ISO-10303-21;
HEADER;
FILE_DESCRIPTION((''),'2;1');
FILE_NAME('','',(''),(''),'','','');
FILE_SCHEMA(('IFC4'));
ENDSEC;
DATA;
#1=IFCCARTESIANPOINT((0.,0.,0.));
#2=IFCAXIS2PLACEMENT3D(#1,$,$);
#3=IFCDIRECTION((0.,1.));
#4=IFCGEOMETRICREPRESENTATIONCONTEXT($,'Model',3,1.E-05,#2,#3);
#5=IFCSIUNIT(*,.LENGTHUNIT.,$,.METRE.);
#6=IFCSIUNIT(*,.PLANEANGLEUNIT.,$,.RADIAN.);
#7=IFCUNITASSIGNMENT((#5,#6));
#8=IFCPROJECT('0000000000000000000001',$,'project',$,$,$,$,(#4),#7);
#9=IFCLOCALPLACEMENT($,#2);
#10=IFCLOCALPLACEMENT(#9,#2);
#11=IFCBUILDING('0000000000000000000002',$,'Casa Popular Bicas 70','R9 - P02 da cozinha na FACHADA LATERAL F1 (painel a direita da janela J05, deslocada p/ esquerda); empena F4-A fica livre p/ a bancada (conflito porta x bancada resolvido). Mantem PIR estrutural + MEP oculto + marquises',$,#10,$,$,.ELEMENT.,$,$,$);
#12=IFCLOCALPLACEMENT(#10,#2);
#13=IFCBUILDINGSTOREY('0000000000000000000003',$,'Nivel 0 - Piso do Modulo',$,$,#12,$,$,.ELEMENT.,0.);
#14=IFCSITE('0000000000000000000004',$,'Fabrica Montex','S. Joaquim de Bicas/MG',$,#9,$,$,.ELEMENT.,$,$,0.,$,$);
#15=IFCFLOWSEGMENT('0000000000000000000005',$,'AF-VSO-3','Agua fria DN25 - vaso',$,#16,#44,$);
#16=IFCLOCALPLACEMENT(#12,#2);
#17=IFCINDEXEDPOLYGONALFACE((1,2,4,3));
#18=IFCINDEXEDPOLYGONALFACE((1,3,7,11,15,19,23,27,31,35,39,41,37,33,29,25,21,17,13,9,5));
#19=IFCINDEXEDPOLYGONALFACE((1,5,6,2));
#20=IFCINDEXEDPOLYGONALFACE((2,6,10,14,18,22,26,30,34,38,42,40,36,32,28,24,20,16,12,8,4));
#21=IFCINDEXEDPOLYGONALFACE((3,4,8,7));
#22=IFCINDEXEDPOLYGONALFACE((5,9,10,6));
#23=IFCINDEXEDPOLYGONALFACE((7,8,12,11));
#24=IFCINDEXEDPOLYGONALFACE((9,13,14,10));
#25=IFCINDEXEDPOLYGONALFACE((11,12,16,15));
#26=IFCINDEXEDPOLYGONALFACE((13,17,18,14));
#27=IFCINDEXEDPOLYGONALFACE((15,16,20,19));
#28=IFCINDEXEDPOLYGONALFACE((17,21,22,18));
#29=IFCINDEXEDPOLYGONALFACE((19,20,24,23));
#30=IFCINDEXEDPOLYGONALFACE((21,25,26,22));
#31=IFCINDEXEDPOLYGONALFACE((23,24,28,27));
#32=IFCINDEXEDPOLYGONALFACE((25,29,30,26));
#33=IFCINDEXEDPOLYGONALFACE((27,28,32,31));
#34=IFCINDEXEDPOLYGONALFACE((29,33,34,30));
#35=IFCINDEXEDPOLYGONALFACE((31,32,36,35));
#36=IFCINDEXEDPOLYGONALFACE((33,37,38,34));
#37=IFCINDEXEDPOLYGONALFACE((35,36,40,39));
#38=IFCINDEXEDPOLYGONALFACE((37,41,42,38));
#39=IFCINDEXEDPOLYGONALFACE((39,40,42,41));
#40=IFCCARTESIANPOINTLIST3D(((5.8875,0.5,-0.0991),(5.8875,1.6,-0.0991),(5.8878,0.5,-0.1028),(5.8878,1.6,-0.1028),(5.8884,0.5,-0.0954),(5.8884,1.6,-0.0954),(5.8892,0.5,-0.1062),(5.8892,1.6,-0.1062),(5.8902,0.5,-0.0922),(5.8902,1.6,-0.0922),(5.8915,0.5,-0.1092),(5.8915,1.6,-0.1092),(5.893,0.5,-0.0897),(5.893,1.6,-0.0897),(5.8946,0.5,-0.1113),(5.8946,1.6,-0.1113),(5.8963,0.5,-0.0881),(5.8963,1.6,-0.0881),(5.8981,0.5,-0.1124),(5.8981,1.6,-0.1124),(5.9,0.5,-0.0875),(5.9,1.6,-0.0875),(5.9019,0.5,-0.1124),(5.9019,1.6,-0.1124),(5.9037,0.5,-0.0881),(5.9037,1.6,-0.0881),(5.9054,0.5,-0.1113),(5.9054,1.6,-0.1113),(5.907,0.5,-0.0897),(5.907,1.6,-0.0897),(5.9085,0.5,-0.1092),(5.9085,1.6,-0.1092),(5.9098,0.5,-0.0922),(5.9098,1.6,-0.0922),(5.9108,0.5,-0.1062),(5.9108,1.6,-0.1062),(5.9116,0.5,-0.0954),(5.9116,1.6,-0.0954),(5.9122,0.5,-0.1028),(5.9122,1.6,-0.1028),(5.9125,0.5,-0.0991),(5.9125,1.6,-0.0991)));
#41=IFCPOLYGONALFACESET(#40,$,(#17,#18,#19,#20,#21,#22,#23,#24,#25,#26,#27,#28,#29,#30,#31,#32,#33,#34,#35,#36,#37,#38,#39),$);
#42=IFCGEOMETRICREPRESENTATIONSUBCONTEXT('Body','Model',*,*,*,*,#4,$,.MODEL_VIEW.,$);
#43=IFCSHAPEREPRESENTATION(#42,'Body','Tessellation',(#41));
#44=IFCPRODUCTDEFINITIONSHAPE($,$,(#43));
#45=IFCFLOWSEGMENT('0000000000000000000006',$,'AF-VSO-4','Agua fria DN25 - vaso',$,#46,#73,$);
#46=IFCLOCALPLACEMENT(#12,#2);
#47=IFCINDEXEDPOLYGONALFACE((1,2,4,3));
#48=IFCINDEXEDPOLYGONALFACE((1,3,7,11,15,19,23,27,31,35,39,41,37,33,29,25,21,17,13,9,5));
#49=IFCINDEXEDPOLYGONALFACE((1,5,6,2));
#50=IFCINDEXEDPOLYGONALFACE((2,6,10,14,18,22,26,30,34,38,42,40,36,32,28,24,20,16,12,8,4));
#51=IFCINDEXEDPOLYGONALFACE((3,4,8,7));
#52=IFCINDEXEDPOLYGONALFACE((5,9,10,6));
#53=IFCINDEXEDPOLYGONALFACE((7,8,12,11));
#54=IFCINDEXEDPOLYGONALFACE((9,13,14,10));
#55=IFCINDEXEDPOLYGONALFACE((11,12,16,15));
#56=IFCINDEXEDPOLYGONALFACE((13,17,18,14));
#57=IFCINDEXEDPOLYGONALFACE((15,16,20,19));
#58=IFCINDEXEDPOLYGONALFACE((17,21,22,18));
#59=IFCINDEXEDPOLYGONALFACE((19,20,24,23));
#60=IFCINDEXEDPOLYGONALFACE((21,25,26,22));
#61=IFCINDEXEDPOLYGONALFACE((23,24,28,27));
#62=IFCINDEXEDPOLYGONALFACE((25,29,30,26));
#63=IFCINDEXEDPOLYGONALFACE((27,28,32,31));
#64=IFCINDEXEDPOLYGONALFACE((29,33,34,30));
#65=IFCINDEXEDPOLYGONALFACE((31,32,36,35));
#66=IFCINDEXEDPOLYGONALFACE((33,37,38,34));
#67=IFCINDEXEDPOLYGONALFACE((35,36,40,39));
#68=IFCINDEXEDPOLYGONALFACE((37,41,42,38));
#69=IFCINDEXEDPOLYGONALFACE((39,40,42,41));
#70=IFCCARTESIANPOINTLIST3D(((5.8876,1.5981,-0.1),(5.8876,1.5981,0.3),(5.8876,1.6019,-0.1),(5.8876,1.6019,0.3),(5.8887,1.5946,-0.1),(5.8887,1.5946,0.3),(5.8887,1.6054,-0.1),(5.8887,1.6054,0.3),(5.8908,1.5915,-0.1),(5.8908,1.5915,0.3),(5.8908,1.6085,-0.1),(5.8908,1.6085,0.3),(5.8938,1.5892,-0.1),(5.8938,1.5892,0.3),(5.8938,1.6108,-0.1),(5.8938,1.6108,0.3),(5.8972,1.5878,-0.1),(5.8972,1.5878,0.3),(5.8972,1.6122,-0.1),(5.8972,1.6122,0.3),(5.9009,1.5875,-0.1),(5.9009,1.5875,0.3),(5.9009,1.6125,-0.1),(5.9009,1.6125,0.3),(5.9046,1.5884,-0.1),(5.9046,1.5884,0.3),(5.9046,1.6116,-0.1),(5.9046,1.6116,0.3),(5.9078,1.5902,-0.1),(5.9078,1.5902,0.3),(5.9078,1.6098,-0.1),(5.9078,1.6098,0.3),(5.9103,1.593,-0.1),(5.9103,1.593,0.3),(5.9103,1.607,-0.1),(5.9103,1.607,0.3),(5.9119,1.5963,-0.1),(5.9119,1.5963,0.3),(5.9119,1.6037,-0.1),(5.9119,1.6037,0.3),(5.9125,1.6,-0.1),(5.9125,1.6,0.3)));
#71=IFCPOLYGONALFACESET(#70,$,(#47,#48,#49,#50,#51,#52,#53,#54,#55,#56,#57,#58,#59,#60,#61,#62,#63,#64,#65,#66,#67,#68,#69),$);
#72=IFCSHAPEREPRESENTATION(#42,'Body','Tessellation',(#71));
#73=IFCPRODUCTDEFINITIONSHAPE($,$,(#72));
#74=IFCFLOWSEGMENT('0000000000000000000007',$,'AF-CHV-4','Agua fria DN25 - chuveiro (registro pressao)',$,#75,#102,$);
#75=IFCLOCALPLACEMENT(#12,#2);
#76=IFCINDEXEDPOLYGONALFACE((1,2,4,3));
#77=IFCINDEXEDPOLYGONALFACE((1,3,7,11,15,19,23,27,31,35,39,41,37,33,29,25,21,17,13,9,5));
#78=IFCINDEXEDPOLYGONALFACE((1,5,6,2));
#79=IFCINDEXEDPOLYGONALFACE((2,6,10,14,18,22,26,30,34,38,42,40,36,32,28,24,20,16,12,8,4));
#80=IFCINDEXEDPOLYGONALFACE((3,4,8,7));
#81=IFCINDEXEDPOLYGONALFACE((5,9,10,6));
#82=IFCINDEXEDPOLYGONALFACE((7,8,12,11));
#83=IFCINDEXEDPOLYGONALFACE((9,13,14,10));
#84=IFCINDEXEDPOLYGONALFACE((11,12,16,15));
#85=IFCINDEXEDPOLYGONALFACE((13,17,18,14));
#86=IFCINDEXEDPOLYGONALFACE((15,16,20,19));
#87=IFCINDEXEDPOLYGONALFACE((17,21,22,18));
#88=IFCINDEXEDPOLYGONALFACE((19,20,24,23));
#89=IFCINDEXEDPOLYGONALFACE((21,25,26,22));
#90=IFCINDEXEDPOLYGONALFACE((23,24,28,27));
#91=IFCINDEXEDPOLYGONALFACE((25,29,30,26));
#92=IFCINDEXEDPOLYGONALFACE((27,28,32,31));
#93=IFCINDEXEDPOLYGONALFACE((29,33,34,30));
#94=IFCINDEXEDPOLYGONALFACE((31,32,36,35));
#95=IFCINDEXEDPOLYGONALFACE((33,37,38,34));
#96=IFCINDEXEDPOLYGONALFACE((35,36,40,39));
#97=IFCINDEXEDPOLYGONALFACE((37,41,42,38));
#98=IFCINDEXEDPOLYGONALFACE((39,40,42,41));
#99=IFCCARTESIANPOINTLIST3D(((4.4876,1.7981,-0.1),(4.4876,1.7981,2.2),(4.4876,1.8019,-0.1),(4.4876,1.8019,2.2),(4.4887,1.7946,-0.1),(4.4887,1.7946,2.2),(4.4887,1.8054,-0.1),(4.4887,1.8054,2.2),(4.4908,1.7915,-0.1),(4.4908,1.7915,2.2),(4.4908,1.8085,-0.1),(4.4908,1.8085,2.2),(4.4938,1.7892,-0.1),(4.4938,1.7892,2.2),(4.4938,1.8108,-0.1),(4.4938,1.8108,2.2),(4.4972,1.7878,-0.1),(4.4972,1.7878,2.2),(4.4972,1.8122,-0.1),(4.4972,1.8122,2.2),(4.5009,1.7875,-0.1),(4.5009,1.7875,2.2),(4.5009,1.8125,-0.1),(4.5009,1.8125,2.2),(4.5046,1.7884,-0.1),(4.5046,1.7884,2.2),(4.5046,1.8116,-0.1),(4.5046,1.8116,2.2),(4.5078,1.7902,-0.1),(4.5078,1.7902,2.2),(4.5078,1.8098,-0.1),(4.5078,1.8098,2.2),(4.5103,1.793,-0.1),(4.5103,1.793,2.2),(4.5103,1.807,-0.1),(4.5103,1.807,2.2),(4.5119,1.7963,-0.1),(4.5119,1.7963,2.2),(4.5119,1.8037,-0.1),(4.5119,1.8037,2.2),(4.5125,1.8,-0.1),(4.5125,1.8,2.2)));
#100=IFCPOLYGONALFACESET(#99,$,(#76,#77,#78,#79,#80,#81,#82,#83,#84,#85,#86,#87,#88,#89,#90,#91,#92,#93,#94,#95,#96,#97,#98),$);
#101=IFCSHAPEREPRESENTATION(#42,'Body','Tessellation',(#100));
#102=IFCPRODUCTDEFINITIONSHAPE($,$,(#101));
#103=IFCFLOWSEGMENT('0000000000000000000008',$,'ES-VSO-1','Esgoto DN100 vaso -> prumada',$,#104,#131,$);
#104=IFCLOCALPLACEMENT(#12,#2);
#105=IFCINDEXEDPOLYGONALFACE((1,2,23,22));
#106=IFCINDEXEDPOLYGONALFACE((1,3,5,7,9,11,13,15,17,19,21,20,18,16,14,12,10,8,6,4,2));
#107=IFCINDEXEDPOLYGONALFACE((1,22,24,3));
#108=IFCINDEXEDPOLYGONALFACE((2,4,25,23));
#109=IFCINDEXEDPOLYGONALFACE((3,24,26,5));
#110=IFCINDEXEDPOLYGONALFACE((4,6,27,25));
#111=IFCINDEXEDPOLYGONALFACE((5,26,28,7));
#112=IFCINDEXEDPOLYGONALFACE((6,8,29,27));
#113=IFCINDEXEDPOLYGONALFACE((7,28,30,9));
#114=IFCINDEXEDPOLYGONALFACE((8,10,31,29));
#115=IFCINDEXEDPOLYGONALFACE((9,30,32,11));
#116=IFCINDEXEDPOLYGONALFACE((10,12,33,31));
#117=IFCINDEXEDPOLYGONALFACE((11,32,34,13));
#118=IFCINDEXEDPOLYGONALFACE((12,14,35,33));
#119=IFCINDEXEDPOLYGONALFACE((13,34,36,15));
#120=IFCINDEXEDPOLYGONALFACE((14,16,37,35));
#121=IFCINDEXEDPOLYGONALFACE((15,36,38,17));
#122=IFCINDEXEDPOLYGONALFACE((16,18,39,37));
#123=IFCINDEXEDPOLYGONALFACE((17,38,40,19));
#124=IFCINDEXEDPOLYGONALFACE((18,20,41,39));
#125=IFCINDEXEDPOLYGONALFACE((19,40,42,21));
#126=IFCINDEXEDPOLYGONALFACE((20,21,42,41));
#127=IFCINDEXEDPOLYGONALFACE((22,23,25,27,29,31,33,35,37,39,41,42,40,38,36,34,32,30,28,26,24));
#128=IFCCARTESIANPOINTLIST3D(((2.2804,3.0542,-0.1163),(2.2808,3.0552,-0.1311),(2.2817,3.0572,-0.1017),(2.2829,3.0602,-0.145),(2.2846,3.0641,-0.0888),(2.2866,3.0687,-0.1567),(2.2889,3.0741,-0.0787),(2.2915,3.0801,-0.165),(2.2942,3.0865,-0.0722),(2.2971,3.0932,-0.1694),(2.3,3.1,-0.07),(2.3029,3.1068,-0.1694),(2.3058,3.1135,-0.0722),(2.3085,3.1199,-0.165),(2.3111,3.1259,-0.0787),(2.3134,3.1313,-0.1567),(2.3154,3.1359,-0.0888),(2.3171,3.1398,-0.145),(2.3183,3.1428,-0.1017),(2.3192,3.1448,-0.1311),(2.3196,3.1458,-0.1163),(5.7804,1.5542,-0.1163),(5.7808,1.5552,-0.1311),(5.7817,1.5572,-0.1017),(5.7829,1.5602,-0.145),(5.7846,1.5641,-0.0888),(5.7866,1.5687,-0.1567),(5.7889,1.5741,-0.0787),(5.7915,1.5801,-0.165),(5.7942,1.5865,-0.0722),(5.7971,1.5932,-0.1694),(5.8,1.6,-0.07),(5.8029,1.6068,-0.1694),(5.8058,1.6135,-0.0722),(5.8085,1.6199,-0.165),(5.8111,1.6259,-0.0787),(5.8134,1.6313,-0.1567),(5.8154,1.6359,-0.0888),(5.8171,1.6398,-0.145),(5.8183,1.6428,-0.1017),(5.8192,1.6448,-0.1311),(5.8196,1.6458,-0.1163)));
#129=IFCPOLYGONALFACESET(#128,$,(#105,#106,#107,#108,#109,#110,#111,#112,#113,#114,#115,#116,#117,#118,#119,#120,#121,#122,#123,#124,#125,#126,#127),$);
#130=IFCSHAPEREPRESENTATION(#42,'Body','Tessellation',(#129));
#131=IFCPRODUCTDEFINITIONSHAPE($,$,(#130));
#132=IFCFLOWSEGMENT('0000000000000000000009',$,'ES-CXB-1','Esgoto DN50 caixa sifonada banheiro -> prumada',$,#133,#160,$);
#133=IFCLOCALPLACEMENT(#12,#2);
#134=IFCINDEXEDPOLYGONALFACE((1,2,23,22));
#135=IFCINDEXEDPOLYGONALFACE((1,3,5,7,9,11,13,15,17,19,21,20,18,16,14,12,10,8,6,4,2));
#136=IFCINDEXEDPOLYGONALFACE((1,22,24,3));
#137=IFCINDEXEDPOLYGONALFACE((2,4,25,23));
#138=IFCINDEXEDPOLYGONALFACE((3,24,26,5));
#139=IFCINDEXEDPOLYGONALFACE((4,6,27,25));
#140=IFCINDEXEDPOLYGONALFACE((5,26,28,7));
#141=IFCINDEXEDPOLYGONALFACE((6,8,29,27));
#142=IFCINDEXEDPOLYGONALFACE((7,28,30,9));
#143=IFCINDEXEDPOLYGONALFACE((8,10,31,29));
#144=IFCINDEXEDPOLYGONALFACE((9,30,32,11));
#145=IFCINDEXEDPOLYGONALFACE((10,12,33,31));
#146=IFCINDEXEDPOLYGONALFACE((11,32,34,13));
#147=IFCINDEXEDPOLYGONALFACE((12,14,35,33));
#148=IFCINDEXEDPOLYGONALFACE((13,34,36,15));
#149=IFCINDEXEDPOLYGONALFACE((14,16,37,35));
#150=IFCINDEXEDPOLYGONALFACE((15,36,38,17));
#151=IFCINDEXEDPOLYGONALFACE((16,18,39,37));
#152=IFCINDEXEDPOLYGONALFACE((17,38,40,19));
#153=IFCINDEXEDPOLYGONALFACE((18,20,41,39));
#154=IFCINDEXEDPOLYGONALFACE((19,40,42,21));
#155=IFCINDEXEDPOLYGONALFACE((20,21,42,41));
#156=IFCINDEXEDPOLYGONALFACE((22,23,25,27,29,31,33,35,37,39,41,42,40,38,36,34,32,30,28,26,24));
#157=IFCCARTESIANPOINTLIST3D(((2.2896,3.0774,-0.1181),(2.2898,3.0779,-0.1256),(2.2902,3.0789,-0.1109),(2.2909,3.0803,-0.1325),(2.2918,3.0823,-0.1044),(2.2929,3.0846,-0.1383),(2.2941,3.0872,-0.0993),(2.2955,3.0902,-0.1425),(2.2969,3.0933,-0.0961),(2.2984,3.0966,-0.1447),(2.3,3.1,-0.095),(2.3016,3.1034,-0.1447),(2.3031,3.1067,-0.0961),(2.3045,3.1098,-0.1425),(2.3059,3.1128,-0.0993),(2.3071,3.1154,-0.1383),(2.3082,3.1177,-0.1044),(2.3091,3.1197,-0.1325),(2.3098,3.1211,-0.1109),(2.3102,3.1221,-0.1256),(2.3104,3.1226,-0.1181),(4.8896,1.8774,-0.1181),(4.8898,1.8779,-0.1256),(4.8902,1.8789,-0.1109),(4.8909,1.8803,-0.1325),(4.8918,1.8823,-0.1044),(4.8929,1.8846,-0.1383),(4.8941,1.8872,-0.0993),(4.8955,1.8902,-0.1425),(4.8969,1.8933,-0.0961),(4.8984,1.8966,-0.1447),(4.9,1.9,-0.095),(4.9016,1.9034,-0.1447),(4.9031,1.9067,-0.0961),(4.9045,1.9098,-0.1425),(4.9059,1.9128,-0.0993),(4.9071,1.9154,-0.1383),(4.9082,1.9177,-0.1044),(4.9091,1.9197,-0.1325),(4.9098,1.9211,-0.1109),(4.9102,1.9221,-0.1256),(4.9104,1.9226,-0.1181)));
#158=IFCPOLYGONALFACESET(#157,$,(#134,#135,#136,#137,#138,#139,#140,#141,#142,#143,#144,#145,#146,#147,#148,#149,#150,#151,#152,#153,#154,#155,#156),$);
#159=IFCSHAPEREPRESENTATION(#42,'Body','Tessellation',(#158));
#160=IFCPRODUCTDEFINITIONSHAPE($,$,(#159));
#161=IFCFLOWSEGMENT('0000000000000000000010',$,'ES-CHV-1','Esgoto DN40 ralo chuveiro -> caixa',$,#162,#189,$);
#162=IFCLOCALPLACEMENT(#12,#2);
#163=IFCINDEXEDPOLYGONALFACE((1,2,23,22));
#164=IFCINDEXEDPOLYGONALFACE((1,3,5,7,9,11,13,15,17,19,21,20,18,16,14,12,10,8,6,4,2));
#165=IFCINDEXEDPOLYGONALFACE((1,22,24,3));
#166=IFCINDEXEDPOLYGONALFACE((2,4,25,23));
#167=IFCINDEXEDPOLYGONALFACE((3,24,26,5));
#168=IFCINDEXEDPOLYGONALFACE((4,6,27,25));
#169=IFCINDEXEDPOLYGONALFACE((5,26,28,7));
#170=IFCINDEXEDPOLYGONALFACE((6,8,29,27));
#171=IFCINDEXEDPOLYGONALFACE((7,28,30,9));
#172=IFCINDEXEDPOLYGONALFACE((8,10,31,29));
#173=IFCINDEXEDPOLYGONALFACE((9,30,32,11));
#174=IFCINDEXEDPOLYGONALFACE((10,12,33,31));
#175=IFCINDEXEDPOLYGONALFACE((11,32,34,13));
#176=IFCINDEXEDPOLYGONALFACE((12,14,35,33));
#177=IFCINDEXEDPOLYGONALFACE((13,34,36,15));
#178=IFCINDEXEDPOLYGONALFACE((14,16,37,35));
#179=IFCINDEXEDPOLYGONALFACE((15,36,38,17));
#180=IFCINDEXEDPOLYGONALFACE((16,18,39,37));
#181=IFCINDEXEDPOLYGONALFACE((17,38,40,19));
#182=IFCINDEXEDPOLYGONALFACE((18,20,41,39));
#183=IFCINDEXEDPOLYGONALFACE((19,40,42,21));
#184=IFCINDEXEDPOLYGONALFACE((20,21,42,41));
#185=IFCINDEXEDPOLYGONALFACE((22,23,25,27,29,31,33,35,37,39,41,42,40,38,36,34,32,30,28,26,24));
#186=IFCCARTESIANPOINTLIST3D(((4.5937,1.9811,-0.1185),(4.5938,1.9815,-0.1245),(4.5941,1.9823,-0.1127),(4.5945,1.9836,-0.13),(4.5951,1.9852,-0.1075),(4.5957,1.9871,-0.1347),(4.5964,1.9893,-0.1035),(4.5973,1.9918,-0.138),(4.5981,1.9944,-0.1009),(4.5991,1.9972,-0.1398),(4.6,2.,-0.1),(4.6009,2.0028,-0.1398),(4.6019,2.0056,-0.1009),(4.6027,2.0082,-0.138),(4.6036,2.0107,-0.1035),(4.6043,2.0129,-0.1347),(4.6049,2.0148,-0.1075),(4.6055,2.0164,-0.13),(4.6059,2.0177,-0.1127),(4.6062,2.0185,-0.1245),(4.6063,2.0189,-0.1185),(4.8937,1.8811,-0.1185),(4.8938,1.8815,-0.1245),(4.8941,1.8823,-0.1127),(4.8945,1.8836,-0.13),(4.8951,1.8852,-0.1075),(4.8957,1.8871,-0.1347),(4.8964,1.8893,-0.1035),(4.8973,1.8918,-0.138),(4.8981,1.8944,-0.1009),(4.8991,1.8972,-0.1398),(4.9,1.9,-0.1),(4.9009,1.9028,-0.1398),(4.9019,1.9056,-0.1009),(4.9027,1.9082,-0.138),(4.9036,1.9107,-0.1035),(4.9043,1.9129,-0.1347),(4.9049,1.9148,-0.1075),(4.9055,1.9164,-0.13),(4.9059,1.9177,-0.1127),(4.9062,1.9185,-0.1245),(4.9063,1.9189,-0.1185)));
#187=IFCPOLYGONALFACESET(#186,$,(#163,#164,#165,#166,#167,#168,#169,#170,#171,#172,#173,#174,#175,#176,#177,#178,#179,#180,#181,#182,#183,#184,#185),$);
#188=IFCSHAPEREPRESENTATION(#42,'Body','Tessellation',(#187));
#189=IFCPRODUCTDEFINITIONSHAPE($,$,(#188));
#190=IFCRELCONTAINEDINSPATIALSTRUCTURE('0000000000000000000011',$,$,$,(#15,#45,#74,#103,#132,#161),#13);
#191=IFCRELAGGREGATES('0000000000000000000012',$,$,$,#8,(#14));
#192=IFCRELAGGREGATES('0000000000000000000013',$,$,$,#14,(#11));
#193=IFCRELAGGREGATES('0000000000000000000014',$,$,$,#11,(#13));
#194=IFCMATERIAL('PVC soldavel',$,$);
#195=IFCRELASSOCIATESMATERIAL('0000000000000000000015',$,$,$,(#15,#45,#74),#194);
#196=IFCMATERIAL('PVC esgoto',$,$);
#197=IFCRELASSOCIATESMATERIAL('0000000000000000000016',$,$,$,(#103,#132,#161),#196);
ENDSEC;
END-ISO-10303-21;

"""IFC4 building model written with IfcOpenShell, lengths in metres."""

from ifc_helpers import new_model, si_unit, direction, frame, origin, origin_2d, place, context, subcontext, project, spatial, circle, extrude, material, element, save


model = new_model("IFC4")

# Units and contexts
model_context = context("Model", 3, precision=1e-05, world=origin(), true_north=direction((0.0, 1.0)))
body_context = subcontext(model_context, "Body", "Model", "MODEL_VIEW")
ifc_project = project(units=[si_unit("LENGTHUNIT", "METRE"), si_unit("PLANEANGLEUNIT", "RADIAN")], contexts=[model_context])

# Site, building, storey
site_placement = place(None, origin())
site = spatial("IfcSite", under=ifc_project, at=site_placement, Name="Fabrica Montex", Description="S. Joaquim de Bicas/MG", CompositionType="ELEMENT", RefElevation=0.0)
building_placement = place(site_placement, origin())
building = spatial("IfcBuilding", under=site, at=building_placement, Name="Casa Popular Bicas 70", Description="R9 - P02 da cozinha na FACHADA LATERAL F1 (painel a direita da janela J05, deslocada p/ esquerda); empena F4-A fica livre p/ a bancada (conflito porta x bancada resolvido). Mantem PIR estrutural + MEP oculto + marquises", CompositionType="ELEMENT")
storey_placement = place(building_placement, origin())
storey = spatial("IfcBuildingStorey", under=building, at=storey_placement, Name="Nivel 0 - Piso do Modulo", CompositionType="ELEMENT", Elevation=0.0)

# Flow segments
ifc_material_1 = material(Name="PVC soldavel")
flow_segment_1_placement = place(storey_placement, frame((5.9, 0.5, -0.1), z_axis=(0.0, 1.0, 0.0), x_axis=(0.0, 0.0, 1.0)))
element("IfcFlowSegment", 1, at=flow_segment_1_placement, inside=storey, material=ifc_material_1, Name="AF-VSO-3", Description="Agua fria DN25 - vaso", context=body_context, shape_type="SweptSolid", body=[
    extrude(circle(Radius=0.0125, at=origin_2d()), origin(), (0.0, 0.0, 1.0), 1.1),
])
flow_segment_2_placement = place(storey_placement, frame((5.9, 1.6, -0.1), z_axis=(0.0, 0.0, 1.0), x_axis=(1.0, 0.0, 0.0)))
element("IfcFlowSegment", 2, at=flow_segment_2_placement, inside=storey, material=ifc_material_1, Name="AF-VSO-4", Description="Agua fria DN25 - vaso", context=body_context, shape_type="SweptSolid", body=[
    extrude(circle(Radius=0.0125, at=origin_2d()), origin(), (0.0, 0.0, 1.0), 0.4),
])
flow_segment_3_placement = place(storey_placement, frame((4.5, 1.8, -0.1), z_axis=(0.0, 0.0, 1.0), x_axis=(1.0, 0.0, 0.0)))
element("IfcFlowSegment", 3, at=flow_segment_3_placement, inside=storey, material=ifc_material_1, Name="AF-CHV-4", Description="Agua fria DN25 - chuveiro (registro pressao)", context=body_context, shape_type="SweptSolid", body=[
    extrude(circle(Radius=0.0125, at=origin_2d()), origin(), (0.0, 0.0, 1.0), 2.3),
])
ifc_material_2 = material(Name="PVC esgoto")
flow_segment_4_placement = place(storey_placement, frame((5.8, 1.6, -0.12), z_axis=(-0.919145, 0.393919, 0.0), x_axis=(0.0, 0.0, 1.0)))
element("IfcFlowSegment", 4, at=flow_segment_4_placement, inside=storey, material=ifc_material_2, Name="ES-VSO-1", Description="Esgoto DN100 vaso -> prumada", context=body_context, shape_type="SweptSolid", body=[
    extrude(circle(Radius=0.05, at=origin_2d()), origin(), (0.0, 0.0, 1.0), 3.8079),
])
flow_segment_5_placement = place(storey_placement, frame((4.9, 1.9, -0.12), z_axis=(-0.907959, 0.419058, 0.0), x_axis=(0.0, 0.0, 1.0)))
element("IfcFlowSegment", 5, at=flow_segment_5_placement, inside=storey, material=ifc_material_2, Name="ES-CXB-1", Description="Esgoto DN50 caixa sifonada banheiro -> prumada", context=body_context, shape_type="SweptSolid", body=[
    extrude(circle(Radius=0.025, at=origin_2d()), origin(), (0.0, 0.0, 1.0), 2.8636),
])
flow_segment_6_placement = place(storey_placement, frame((4.6, 2.0, -0.12), z_axis=(0.948683, -0.316228, 0.0), x_axis=(0.0, 0.0, 1.0)))
element("IfcFlowSegment", 6, at=flow_segment_6_placement, inside=storey, material=ifc_material_2, Name="ES-CHV-1", Description="Esgoto DN40 ralo chuveiro -> caixa", context=body_context, shape_type="SweptSolid", body=[
    extrude(circle(Radius=0.02, at=origin_2d()), origin(), (0.0, 0.0, 1.0), 0.3162),
])

save(model, "model.ifc")
